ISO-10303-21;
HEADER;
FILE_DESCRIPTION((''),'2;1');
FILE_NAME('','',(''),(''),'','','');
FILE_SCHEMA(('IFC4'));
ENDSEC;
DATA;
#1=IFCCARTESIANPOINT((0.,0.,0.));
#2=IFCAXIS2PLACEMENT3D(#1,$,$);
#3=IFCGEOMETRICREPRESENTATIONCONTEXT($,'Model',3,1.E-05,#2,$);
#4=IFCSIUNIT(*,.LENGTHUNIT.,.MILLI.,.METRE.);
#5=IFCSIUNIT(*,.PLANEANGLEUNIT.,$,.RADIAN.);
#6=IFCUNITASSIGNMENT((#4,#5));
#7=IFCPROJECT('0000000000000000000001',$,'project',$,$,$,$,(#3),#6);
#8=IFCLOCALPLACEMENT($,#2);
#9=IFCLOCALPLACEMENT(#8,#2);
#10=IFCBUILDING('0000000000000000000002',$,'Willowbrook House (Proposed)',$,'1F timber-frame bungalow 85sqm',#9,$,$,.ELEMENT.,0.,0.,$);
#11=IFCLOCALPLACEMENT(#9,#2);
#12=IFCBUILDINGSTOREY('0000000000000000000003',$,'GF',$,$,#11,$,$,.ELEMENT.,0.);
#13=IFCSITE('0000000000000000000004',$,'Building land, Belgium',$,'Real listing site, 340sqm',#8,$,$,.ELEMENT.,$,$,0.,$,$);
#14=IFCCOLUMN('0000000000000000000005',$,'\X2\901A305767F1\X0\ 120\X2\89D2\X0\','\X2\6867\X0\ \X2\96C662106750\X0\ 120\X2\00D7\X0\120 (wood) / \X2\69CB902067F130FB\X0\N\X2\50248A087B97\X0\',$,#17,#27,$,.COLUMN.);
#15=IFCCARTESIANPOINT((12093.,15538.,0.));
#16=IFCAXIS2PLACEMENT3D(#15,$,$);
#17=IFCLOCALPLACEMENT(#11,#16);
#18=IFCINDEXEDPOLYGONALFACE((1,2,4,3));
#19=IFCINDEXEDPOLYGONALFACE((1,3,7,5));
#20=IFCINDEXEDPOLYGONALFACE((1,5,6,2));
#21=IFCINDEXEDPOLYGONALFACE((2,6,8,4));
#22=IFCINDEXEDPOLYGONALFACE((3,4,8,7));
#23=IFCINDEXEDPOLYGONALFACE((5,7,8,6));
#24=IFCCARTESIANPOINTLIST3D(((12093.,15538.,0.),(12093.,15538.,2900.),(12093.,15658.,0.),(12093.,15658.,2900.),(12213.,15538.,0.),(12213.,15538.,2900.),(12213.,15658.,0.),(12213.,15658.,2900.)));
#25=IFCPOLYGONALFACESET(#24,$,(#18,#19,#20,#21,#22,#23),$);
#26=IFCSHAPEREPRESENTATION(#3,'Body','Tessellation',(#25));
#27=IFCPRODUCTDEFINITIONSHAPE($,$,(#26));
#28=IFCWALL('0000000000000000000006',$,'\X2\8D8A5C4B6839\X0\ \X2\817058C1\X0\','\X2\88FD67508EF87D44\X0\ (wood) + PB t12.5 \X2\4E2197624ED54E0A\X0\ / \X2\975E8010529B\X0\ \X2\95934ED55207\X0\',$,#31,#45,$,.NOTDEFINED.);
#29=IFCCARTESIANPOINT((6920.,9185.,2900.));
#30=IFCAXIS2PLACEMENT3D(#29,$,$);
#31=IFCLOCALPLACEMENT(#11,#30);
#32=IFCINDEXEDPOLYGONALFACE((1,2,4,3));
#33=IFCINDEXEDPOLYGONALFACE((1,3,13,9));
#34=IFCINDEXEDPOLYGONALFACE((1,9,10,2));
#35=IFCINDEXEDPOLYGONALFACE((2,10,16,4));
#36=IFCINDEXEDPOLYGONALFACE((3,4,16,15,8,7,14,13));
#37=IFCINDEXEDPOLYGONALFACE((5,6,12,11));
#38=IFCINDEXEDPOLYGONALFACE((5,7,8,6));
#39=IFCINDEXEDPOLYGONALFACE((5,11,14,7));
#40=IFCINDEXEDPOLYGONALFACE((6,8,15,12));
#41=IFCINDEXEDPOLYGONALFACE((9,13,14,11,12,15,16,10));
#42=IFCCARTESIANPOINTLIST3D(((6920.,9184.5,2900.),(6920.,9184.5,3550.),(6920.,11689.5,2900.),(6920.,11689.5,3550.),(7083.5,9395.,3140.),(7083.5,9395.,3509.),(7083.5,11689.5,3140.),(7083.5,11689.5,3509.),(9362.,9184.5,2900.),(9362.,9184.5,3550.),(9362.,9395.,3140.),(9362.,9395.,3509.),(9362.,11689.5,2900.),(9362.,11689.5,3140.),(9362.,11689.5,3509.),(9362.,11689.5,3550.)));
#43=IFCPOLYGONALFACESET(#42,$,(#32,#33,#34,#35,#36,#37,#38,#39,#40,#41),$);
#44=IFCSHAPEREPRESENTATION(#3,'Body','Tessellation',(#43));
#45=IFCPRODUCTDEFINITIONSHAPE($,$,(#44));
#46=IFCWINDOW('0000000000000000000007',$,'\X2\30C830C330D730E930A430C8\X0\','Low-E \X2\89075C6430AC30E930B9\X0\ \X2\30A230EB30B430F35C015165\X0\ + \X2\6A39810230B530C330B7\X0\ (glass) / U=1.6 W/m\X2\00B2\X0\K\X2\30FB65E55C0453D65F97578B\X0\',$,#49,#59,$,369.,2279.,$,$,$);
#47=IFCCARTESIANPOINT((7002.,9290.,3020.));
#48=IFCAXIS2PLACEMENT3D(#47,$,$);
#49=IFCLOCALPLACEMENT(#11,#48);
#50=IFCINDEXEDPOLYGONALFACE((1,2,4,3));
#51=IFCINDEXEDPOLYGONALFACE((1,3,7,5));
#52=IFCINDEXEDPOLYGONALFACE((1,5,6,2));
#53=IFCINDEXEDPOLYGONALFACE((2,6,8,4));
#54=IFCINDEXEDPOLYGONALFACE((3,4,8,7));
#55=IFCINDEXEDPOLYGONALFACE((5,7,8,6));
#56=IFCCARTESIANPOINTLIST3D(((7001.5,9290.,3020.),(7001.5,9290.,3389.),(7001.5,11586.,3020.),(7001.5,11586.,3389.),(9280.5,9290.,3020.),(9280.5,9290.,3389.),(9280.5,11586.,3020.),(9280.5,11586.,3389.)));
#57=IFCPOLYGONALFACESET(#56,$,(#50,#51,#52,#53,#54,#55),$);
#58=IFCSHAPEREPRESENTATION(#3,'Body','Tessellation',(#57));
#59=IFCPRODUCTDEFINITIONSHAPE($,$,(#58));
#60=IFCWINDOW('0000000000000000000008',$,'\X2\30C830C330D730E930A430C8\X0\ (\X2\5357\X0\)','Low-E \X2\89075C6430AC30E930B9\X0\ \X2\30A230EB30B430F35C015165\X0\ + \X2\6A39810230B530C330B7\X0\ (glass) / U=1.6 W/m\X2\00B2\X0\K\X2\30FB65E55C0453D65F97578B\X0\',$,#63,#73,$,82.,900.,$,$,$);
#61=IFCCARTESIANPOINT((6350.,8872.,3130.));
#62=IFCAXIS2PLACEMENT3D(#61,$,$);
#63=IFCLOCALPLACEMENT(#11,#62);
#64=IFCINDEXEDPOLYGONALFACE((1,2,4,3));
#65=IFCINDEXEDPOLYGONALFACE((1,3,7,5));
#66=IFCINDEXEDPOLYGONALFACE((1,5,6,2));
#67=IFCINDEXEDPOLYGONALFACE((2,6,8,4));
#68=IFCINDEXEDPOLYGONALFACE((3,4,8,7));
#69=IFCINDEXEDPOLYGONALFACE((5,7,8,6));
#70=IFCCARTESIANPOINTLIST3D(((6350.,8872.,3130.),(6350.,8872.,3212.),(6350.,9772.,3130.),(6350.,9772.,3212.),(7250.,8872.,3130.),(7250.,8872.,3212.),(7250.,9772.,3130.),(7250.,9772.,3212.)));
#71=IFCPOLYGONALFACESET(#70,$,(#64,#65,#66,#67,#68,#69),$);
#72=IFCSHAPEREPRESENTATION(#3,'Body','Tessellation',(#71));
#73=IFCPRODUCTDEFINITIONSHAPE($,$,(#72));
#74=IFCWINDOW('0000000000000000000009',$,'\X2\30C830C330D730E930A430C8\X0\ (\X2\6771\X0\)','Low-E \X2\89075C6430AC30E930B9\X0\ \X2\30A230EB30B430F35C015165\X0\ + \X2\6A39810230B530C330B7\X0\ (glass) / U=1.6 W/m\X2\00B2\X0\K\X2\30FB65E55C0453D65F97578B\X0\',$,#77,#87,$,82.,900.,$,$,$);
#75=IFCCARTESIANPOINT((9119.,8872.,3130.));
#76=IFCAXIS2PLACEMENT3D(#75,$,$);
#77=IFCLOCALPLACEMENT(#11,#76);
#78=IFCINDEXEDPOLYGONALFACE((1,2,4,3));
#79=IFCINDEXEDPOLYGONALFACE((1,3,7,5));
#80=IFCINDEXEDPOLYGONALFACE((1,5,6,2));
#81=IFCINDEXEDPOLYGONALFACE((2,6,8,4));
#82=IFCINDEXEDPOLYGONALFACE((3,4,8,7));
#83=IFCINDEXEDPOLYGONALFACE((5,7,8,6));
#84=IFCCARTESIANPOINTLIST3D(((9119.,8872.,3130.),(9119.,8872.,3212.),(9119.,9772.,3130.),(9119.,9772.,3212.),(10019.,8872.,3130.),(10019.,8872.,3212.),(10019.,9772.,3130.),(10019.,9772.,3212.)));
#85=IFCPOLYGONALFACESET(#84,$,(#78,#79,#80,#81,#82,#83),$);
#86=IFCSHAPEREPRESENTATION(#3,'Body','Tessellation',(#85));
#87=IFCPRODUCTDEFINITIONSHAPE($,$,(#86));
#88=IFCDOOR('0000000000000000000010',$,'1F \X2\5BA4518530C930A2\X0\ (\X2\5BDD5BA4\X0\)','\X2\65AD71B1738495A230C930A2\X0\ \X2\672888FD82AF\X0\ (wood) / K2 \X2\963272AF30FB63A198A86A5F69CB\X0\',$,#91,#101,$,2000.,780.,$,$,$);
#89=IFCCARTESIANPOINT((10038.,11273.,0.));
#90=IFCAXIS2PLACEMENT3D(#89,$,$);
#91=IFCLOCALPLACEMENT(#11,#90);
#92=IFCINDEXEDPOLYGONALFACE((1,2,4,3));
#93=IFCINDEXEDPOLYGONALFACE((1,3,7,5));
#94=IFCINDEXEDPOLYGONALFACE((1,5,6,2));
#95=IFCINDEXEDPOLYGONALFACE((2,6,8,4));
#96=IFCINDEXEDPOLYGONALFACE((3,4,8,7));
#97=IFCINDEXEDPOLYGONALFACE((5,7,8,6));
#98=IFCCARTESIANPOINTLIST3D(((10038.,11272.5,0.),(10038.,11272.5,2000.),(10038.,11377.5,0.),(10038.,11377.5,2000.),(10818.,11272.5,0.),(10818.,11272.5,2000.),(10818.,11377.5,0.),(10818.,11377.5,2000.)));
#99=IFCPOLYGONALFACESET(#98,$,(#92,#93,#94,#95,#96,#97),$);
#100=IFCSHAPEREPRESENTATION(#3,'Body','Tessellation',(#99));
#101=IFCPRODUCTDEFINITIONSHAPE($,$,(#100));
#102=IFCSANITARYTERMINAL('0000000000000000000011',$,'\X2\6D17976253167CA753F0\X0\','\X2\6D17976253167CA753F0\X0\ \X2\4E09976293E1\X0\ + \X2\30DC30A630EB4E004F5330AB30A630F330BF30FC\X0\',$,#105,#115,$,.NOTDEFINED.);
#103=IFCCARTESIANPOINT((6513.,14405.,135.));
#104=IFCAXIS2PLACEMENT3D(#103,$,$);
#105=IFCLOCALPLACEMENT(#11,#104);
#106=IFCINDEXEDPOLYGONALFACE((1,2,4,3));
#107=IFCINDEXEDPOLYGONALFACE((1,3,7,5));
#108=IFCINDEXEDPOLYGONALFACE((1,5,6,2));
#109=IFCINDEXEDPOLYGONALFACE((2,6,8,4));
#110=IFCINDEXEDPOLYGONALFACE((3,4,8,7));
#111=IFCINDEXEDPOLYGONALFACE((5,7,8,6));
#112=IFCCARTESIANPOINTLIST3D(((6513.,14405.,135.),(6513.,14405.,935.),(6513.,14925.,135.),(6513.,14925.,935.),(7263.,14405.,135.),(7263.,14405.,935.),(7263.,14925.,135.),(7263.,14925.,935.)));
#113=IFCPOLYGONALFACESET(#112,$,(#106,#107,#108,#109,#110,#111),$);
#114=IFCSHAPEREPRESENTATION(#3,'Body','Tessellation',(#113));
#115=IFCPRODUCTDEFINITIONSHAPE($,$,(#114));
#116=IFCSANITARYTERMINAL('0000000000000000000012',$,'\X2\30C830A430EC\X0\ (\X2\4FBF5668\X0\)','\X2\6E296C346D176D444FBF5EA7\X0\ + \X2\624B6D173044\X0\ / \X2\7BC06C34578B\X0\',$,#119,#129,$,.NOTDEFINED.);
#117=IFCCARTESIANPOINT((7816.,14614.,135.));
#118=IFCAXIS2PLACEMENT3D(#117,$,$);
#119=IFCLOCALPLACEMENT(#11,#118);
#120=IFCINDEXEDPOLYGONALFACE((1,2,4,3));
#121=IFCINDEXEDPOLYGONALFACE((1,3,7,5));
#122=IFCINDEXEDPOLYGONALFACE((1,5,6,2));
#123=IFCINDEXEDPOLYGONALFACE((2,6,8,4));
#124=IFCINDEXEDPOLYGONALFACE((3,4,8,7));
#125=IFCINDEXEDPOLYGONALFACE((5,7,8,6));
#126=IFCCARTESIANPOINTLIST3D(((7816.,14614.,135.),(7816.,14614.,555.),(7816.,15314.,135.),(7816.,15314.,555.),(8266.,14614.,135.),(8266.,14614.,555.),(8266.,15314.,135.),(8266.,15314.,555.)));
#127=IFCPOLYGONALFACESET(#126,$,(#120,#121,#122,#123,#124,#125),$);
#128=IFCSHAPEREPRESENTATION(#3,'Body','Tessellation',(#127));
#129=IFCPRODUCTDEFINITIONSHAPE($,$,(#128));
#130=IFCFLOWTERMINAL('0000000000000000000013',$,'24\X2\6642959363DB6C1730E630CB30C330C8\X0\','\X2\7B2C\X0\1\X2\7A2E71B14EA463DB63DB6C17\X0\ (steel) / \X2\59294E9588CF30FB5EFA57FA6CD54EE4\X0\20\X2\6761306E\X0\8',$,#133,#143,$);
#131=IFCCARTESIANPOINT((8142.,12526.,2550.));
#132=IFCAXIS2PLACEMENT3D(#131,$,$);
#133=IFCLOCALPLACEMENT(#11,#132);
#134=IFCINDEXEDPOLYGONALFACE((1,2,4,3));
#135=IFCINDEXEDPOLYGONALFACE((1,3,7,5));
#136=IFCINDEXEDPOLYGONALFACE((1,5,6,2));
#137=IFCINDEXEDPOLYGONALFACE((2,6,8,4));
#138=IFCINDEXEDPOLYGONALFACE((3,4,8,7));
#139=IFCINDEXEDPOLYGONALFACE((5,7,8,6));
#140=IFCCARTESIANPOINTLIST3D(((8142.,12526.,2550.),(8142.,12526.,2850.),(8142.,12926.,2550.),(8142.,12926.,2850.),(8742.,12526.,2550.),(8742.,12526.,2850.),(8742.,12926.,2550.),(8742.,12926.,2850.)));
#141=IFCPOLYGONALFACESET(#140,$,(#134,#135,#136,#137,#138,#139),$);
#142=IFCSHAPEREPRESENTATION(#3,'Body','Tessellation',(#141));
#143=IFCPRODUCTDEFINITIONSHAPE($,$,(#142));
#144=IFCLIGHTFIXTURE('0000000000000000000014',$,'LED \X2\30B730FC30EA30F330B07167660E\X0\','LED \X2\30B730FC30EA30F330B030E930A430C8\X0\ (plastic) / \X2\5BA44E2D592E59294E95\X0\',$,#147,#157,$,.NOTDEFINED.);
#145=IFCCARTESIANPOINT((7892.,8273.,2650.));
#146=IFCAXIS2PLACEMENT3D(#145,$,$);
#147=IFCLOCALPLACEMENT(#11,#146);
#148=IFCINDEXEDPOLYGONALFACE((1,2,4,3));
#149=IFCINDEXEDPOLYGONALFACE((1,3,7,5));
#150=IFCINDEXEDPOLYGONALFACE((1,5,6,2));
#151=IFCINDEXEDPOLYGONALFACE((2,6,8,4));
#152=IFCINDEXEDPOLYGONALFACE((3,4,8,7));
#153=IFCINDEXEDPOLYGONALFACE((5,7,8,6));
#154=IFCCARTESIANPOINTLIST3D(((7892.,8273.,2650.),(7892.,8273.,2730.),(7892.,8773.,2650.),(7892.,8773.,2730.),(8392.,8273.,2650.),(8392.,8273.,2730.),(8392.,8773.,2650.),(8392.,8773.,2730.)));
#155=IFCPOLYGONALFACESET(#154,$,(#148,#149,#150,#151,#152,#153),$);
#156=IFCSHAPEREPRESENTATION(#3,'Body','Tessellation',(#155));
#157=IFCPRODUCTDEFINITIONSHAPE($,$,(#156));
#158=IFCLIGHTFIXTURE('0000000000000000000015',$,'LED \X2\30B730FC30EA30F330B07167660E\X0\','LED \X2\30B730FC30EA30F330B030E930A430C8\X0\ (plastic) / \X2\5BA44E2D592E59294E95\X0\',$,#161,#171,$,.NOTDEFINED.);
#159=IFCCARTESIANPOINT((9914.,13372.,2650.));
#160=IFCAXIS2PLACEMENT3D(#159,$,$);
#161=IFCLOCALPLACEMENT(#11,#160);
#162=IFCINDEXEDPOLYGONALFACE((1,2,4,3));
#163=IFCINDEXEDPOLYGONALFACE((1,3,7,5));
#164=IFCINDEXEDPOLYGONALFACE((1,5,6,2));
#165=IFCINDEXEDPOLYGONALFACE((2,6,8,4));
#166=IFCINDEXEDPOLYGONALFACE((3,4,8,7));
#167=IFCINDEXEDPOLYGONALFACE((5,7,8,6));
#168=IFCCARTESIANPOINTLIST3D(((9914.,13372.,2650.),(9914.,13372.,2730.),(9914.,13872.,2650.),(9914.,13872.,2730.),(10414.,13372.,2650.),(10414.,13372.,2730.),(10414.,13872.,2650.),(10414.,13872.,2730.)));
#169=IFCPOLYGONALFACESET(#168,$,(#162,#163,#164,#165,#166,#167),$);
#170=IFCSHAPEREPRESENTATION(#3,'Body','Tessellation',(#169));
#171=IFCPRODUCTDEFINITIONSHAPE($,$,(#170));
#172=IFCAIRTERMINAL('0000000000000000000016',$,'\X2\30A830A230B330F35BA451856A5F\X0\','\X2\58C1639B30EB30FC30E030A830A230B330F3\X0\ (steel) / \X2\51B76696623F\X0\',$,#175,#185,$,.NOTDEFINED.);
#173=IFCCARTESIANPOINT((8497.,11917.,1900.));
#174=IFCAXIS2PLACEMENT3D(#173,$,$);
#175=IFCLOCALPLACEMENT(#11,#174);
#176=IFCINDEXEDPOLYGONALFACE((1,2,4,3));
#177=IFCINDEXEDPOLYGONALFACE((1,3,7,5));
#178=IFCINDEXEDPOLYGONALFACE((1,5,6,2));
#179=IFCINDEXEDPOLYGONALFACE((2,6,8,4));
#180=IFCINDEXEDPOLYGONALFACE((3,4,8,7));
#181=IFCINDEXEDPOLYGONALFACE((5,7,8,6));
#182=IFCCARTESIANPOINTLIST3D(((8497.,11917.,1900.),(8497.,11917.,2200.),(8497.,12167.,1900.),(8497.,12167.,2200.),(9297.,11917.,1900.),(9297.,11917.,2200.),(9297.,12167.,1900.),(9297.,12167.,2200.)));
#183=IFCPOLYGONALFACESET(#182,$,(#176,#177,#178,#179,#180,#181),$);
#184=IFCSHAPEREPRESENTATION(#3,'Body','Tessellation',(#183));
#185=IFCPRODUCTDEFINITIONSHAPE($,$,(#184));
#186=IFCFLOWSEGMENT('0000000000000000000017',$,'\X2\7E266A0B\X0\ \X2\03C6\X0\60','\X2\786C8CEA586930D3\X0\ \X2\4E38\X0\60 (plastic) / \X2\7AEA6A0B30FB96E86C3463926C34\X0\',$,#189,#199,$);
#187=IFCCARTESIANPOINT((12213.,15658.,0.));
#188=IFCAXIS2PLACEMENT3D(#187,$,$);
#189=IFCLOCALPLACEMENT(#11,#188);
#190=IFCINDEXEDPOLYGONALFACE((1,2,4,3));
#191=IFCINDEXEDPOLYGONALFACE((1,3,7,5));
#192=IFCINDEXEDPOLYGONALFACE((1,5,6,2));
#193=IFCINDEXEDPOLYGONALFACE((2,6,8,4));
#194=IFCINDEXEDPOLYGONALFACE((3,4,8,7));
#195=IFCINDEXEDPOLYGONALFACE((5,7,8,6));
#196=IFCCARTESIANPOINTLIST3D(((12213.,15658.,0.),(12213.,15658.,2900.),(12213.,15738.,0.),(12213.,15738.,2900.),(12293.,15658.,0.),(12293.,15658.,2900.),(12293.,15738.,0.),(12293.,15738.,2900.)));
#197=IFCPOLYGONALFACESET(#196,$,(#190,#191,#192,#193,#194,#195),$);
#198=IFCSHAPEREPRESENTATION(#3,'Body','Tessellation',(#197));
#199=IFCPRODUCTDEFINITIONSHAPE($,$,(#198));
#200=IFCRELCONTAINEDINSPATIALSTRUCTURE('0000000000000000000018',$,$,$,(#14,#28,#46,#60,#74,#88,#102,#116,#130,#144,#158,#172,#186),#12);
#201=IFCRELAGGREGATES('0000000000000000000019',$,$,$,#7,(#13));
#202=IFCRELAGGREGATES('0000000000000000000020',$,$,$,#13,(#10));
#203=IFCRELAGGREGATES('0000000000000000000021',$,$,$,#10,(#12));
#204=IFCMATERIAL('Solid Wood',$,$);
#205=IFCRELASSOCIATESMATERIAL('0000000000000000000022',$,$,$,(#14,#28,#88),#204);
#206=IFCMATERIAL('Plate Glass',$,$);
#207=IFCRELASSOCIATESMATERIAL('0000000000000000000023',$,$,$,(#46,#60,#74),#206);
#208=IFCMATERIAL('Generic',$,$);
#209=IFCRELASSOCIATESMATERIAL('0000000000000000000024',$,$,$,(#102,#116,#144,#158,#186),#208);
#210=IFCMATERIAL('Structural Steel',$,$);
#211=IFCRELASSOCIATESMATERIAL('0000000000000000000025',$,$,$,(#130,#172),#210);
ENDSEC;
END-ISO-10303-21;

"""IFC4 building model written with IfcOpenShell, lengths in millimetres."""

from ifc_helpers import new_model, si_unit, frame, frame_2d, origin, place, context, project, spatial, rectangle, extrude, material, element, fill, save


model = new_model("IFC4")

# Units and contexts
model_context = context("Model", 3, precision=1e-05, world=origin())
ifc_project = project(units=[si_unit("LENGTHUNIT", "METRE", prefix="MILLI"), si_unit("PLANEANGLEUNIT", "RADIAN")], contexts=[model_context])

# Site, building, storey
site_placement = place(None, origin())
site = spatial("IfcSite", under=ifc_project, at=site_placement, Name="Building land, Belgium", ObjectType="Real listing site, 340sqm", CompositionType="ELEMENT", RefElevation=0.0)
building_placement = place(site_placement, origin())
building = spatial("IfcBuilding", under=site, at=building_placement, Name="Willowbrook House (Proposed)", ObjectType="1F timber-frame bungalow 85sqm", CompositionType="ELEMENT", ElevationOfRefHeight=0.0, ElevationOfTerrain=0.0)
storey_placement = place(building_placement, origin())
storey = spatial("IfcBuildingStorey", under=building, at=storey_placement, Name="GF", CompositionType="ELEMENT", Elevation=0.0)

# Column
ifc_material_1 = material(Name="Solid Wood")
column_1_placement = place(storey_placement, frame((12093.0, 15538.0, 0.0)))
element("IfcColumn", 1, at=column_1_placement, inside=storey, material=ifc_material_1, Name="通し柱 120角", Description="桧 集成材 120×120 (wood) / 構造柱・N値計算", PredefinedType="COLUMN", context=model_context, shape_type="SweptSolid", body=[
    extrude(rectangle(XDim=120.0, YDim=120.0, at=frame_2d((60.0, 60.0))), frame((12093.0, 15538.0, 0.0)), (0.0, 0.0, 1.0), 2900.0),
])

# Wall, openings, windows
wall_1_placement = place(storey_placement, frame((6920.0, 9185.0, 2900.0)))
wall_1 = element("IfcWall", 2, at=wall_1_placement, inside=storey, material=ifc_material_1, Name="越屋根 腰壁", Description="製材軸組 (wood) + PB t12.5 両面仕上 / 非耐力 間仕切", PredefinedType="NOTDEFINED", context=model_context, shape_type="SweptSolid", body=[
    extrude(rectangle(XDim=2442.0, YDim=2505.0, at=frame_2d((1221.0, 1252.0))), frame((6920.0, 9185.0, 2900.0)), (0.0, 0.0, 1.0), 650.0),
])
opening_1_placement = place(storey_placement, frame((7002.0, 9290.0, 3020.0)))
opening_1 = element("IfcOpeningElement", 3, at=opening_1_placement, cuts=wall_1, PredefinedType="NOTDEFINED", context=model_context, shape_type="SweptSolid", body=[
    extrude(rectangle(XDim=2279.0, YDim=2296.0, at=frame_2d((1139.0, 1148.0))), frame((7002.0, 9290.0, 3020.0)), (0.0, 0.0, 1.0), 369.0),
])
opening_2_placement = place(storey_placement, frame((6350.0, 8872.0, 3130.0)))
opening_2 = element("IfcOpeningElement", 4, at=opening_2_placement, cuts=wall_1, PredefinedType="NOTDEFINED", context=model_context, shape_type="SweptSolid", body=[
    extrude(rectangle(XDim=900.0, YDim=900.0, at=frame_2d((450.0, 450.0))), frame((6350.0, 8872.0, 3130.0)), (0.0, 0.0, 1.0), 82.0),
])
opening_3_placement = place(storey_placement, frame((9119.0, 8872.0, 3130.0)))
opening_3 = element("IfcOpeningElement", 5, at=opening_3_placement, cuts=wall_1, PredefinedType="NOTDEFINED", context=model_context, shape_type="SweptSolid", body=[
    extrude(rectangle(XDim=900.0, YDim=900.0, at=frame_2d((450.0, 450.0))), frame((9119.0, 8872.0, 3130.0)), (0.0, 0.0, 1.0), 82.0),
])
ifc_material_2 = material(Name="Plate Glass")
window_1_placement = place(storey_placement, frame((7002.0, 9290.0, 3020.0)))
window_1 = element("IfcWindow", 6, at=window_1_placement, inside=storey, material=ifc_material_2, Name="トップライト", Description="Low-E 複層ガラス アルゴン封入 + 樹脂サッシ (glass) / U=1.6 W/m²K・日射取得型", OverallHeight=369.0, OverallWidth=2279.0, context=model_context, shape_type="SweptSolid", body=[
    extrude(rectangle(XDim=2279.0, YDim=2296.0, at=frame_2d((1139.0, 1148.0))), frame((7002.0, 9290.0, 3020.0)), (0.0, 0.0, 1.0), 369.0),
])
fill(opening_1, window_1)
window_2_placement = place(storey_placement, frame((6350.0, 8872.0, 3130.0)))
window_2 = element("IfcWindow", 7, at=window_2_placement, inside=storey, material=ifc_material_2, Name="トップライト (南)", Description="Low-E 複層ガラス アルゴン封入 + 樹脂サッシ (glass) / U=1.6 W/m²K・日射取得型", OverallHeight=82.0, OverallWidth=900.0, context=model_context, shape_type="SweptSolid", body=[
    extrude(rectangle(XDim=900.0, YDim=900.0, at=frame_2d((450.0, 450.0))), frame((6350.0, 8872.0, 3130.0)), (0.0, 0.0, 1.0), 82.0),
])
fill(opening_2, window_2)
window_3_placement = place(storey_placement, frame((9119.0, 8872.0, 3130.0)))
window_3 = element("IfcWindow", 8, at=window_3_placement, inside=storey, material=ifc_material_2, Name="トップライト (東)", Description="Low-E 複層ガラス アルゴン封入 + 樹脂サッシ (glass) / U=1.6 W/m²K・日射取得型", OverallHeight=82.0, OverallWidth=900.0, context=model_context, shape_type="SweptSolid", body=[
    extrude(rectangle(XDim=900.0, YDim=900.0, at=frame_2d((450.0, 450.0))), frame((9119.0, 8872.0, 3130.0)), (0.0, 0.0, 1.0), 82.0),
])
fill(opening_3, window_3)

# Door
door_placement = place(storey_placement, frame((10038.0, 11273.0, 0.0)))
element("IfcDoor", 9, at=door_placement, inside=storey, material=ifc_material_1, Name="1F 室内ドア (寝室)", Description="断熱玄関ドア 木製芯 (wood) / K2 防犯・採風機構", OverallHeight=2000.0, OverallWidth=780.0, context=model_context, shape_type="SweptSolid", body=[
    extrude(rectangle(XDim=780.0, YDim=105.0, at=frame_2d((390.0, 52.0))), frame((10038.0, 11273.0, 0.0)), (0.0, 0.0, 1.0), 2000.0),
])

# Shared definitions
ifc_material_3 = material(Name="Structural Steel")

# Sanitary terminals
ifc_material_4 = material(Name="Generic")
sanitary_terminal_1_placement = place(storey_placement, frame((6513.0, 14405.0, 135.0)))
element("IfcSanitaryTerminal", 10, at=sanitary_terminal_1_placement, inside=storey, material=ifc_material_4, Name="洗面化粧台", Description="洗面化粧台 三面鏡 + ボウル一体カウンター", PredefinedType="NOTDEFINED", context=model_context, shape_type="SweptSolid", body=[
    extrude(rectangle(XDim=750.0, YDim=520.0, at=frame_2d((375.0, 260.0))), frame((6513.0, 14405.0, 135.0)), (0.0, 0.0, 1.0), 800.0),
])
sanitary_terminal_2_placement = place(storey_placement, frame((7816.0, 14614.0, 135.0)))
element("IfcSanitaryTerminal", 11, at=sanitary_terminal_2_placement, inside=storey, material=ifc_material_4, Name="トイレ (便器)", Description="温水洗浄便座 + 手洗い / 節水型", PredefinedType="NOTDEFINED", context=model_context, shape_type="SweptSolid", body=[
    extrude(rectangle(XDim=450.0, YDim=700.0, at=frame_2d((225.0, 350.0))), frame((7816.0, 14614.0, 135.0)), (0.0, 0.0, 1.0), 420.0),
])

# Flow terminal
flow_terminal_placement = place(storey_placement, frame((8142.0, 12526.0, 2550.0)))
element("IfcFlowTerminal", 12, at=flow_terminal_placement, inside=storey, material=ifc_material_3, Name="24時間換気ユニット", Description="第1種熱交換換気 (steel) / 天井裏・建基法令20条の8", context=model_context, shape_type="SweptSolid", body=[
    extrude(rectangle(XDim=600.0, YDim=400.0, at=frame_2d((300.0, 200.0))), frame((8142.0, 12526.0, 2550.0)), (0.0, 0.0, 1.0), 300.0),
])

# Light fixtures
light_fixture_1_placement = place(storey_placement, frame((7892.0, 8273.0, 2650.0)))
element("IfcLightFixture", 13, at=light_fixture_1_placement, inside=storey, material=ifc_material_4, Name="LED シーリング照明", Description="LED シーリングライト (plastic) / 室中央天井", PredefinedType="NOTDEFINED", context=model_context, shape_type="SweptSolid", body=[
    extrude(rectangle(XDim=500.0, YDim=500.0, at=frame_2d((250.0, 250.0))), frame((7892.0, 8273.0, 2650.0)), (0.0, 0.0, 1.0), 80.0),
])
light_fixture_2_placement = place(storey_placement, frame((9914.0, 13372.0, 2650.0)))
element("IfcLightFixture", 14, at=light_fixture_2_placement, inside=storey, material=ifc_material_4, Name="LED シーリング照明", Description="LED シーリングライト (plastic) / 室中央天井", PredefinedType="NOTDEFINED", context=model_context, shape_type="SweptSolid", body=[
    extrude(rectangle(XDim=500.0, YDim=500.0, at=frame_2d((250.0, 250.0))), frame((9914.0, 13372.0, 2650.0)), (0.0, 0.0, 1.0), 80.0),
])

# Air terminal
air_terminal_placement = place(storey_placement, frame((8497.0, 11917.0, 1900.0)))
element("IfcAirTerminal", 15, at=air_terminal_placement, inside=storey, material=ifc_material_3, Name="エアコン室内機", Description="壁掛ルームエアコン (steel) / 冷暖房", PredefinedType="NOTDEFINED", context=model_context, shape_type="SweptSolid", body=[
    extrude(rectangle(XDim=800.0, YDim=250.0, at=frame_2d((400.0, 125.0))), frame((8497.0, 11917.0, 1900.0)), (0.0, 0.0, 1.0), 300.0),
])

# Flow segment
flow_segment_placement = place(storey_placement, frame((12213.0, 15658.0, 0.0)))
element("IfcFlowSegment", 16, at=flow_segment_placement, inside=storey, material=ifc_material_4, Name="縦樋 φ60", Description="硬質塩ビ 丸60 (plastic) / 竪樋・雨水排水", context=model_context, shape_type="SweptSolid", body=[
    extrude(rectangle(XDim=80.0, YDim=80.0, at=frame_2d((40.0, 40.0))), frame((12213.0, 15658.0, 0.0)), (0.0, 0.0, 1.0), 2900.0),
])

save(model, "model.ifc")
